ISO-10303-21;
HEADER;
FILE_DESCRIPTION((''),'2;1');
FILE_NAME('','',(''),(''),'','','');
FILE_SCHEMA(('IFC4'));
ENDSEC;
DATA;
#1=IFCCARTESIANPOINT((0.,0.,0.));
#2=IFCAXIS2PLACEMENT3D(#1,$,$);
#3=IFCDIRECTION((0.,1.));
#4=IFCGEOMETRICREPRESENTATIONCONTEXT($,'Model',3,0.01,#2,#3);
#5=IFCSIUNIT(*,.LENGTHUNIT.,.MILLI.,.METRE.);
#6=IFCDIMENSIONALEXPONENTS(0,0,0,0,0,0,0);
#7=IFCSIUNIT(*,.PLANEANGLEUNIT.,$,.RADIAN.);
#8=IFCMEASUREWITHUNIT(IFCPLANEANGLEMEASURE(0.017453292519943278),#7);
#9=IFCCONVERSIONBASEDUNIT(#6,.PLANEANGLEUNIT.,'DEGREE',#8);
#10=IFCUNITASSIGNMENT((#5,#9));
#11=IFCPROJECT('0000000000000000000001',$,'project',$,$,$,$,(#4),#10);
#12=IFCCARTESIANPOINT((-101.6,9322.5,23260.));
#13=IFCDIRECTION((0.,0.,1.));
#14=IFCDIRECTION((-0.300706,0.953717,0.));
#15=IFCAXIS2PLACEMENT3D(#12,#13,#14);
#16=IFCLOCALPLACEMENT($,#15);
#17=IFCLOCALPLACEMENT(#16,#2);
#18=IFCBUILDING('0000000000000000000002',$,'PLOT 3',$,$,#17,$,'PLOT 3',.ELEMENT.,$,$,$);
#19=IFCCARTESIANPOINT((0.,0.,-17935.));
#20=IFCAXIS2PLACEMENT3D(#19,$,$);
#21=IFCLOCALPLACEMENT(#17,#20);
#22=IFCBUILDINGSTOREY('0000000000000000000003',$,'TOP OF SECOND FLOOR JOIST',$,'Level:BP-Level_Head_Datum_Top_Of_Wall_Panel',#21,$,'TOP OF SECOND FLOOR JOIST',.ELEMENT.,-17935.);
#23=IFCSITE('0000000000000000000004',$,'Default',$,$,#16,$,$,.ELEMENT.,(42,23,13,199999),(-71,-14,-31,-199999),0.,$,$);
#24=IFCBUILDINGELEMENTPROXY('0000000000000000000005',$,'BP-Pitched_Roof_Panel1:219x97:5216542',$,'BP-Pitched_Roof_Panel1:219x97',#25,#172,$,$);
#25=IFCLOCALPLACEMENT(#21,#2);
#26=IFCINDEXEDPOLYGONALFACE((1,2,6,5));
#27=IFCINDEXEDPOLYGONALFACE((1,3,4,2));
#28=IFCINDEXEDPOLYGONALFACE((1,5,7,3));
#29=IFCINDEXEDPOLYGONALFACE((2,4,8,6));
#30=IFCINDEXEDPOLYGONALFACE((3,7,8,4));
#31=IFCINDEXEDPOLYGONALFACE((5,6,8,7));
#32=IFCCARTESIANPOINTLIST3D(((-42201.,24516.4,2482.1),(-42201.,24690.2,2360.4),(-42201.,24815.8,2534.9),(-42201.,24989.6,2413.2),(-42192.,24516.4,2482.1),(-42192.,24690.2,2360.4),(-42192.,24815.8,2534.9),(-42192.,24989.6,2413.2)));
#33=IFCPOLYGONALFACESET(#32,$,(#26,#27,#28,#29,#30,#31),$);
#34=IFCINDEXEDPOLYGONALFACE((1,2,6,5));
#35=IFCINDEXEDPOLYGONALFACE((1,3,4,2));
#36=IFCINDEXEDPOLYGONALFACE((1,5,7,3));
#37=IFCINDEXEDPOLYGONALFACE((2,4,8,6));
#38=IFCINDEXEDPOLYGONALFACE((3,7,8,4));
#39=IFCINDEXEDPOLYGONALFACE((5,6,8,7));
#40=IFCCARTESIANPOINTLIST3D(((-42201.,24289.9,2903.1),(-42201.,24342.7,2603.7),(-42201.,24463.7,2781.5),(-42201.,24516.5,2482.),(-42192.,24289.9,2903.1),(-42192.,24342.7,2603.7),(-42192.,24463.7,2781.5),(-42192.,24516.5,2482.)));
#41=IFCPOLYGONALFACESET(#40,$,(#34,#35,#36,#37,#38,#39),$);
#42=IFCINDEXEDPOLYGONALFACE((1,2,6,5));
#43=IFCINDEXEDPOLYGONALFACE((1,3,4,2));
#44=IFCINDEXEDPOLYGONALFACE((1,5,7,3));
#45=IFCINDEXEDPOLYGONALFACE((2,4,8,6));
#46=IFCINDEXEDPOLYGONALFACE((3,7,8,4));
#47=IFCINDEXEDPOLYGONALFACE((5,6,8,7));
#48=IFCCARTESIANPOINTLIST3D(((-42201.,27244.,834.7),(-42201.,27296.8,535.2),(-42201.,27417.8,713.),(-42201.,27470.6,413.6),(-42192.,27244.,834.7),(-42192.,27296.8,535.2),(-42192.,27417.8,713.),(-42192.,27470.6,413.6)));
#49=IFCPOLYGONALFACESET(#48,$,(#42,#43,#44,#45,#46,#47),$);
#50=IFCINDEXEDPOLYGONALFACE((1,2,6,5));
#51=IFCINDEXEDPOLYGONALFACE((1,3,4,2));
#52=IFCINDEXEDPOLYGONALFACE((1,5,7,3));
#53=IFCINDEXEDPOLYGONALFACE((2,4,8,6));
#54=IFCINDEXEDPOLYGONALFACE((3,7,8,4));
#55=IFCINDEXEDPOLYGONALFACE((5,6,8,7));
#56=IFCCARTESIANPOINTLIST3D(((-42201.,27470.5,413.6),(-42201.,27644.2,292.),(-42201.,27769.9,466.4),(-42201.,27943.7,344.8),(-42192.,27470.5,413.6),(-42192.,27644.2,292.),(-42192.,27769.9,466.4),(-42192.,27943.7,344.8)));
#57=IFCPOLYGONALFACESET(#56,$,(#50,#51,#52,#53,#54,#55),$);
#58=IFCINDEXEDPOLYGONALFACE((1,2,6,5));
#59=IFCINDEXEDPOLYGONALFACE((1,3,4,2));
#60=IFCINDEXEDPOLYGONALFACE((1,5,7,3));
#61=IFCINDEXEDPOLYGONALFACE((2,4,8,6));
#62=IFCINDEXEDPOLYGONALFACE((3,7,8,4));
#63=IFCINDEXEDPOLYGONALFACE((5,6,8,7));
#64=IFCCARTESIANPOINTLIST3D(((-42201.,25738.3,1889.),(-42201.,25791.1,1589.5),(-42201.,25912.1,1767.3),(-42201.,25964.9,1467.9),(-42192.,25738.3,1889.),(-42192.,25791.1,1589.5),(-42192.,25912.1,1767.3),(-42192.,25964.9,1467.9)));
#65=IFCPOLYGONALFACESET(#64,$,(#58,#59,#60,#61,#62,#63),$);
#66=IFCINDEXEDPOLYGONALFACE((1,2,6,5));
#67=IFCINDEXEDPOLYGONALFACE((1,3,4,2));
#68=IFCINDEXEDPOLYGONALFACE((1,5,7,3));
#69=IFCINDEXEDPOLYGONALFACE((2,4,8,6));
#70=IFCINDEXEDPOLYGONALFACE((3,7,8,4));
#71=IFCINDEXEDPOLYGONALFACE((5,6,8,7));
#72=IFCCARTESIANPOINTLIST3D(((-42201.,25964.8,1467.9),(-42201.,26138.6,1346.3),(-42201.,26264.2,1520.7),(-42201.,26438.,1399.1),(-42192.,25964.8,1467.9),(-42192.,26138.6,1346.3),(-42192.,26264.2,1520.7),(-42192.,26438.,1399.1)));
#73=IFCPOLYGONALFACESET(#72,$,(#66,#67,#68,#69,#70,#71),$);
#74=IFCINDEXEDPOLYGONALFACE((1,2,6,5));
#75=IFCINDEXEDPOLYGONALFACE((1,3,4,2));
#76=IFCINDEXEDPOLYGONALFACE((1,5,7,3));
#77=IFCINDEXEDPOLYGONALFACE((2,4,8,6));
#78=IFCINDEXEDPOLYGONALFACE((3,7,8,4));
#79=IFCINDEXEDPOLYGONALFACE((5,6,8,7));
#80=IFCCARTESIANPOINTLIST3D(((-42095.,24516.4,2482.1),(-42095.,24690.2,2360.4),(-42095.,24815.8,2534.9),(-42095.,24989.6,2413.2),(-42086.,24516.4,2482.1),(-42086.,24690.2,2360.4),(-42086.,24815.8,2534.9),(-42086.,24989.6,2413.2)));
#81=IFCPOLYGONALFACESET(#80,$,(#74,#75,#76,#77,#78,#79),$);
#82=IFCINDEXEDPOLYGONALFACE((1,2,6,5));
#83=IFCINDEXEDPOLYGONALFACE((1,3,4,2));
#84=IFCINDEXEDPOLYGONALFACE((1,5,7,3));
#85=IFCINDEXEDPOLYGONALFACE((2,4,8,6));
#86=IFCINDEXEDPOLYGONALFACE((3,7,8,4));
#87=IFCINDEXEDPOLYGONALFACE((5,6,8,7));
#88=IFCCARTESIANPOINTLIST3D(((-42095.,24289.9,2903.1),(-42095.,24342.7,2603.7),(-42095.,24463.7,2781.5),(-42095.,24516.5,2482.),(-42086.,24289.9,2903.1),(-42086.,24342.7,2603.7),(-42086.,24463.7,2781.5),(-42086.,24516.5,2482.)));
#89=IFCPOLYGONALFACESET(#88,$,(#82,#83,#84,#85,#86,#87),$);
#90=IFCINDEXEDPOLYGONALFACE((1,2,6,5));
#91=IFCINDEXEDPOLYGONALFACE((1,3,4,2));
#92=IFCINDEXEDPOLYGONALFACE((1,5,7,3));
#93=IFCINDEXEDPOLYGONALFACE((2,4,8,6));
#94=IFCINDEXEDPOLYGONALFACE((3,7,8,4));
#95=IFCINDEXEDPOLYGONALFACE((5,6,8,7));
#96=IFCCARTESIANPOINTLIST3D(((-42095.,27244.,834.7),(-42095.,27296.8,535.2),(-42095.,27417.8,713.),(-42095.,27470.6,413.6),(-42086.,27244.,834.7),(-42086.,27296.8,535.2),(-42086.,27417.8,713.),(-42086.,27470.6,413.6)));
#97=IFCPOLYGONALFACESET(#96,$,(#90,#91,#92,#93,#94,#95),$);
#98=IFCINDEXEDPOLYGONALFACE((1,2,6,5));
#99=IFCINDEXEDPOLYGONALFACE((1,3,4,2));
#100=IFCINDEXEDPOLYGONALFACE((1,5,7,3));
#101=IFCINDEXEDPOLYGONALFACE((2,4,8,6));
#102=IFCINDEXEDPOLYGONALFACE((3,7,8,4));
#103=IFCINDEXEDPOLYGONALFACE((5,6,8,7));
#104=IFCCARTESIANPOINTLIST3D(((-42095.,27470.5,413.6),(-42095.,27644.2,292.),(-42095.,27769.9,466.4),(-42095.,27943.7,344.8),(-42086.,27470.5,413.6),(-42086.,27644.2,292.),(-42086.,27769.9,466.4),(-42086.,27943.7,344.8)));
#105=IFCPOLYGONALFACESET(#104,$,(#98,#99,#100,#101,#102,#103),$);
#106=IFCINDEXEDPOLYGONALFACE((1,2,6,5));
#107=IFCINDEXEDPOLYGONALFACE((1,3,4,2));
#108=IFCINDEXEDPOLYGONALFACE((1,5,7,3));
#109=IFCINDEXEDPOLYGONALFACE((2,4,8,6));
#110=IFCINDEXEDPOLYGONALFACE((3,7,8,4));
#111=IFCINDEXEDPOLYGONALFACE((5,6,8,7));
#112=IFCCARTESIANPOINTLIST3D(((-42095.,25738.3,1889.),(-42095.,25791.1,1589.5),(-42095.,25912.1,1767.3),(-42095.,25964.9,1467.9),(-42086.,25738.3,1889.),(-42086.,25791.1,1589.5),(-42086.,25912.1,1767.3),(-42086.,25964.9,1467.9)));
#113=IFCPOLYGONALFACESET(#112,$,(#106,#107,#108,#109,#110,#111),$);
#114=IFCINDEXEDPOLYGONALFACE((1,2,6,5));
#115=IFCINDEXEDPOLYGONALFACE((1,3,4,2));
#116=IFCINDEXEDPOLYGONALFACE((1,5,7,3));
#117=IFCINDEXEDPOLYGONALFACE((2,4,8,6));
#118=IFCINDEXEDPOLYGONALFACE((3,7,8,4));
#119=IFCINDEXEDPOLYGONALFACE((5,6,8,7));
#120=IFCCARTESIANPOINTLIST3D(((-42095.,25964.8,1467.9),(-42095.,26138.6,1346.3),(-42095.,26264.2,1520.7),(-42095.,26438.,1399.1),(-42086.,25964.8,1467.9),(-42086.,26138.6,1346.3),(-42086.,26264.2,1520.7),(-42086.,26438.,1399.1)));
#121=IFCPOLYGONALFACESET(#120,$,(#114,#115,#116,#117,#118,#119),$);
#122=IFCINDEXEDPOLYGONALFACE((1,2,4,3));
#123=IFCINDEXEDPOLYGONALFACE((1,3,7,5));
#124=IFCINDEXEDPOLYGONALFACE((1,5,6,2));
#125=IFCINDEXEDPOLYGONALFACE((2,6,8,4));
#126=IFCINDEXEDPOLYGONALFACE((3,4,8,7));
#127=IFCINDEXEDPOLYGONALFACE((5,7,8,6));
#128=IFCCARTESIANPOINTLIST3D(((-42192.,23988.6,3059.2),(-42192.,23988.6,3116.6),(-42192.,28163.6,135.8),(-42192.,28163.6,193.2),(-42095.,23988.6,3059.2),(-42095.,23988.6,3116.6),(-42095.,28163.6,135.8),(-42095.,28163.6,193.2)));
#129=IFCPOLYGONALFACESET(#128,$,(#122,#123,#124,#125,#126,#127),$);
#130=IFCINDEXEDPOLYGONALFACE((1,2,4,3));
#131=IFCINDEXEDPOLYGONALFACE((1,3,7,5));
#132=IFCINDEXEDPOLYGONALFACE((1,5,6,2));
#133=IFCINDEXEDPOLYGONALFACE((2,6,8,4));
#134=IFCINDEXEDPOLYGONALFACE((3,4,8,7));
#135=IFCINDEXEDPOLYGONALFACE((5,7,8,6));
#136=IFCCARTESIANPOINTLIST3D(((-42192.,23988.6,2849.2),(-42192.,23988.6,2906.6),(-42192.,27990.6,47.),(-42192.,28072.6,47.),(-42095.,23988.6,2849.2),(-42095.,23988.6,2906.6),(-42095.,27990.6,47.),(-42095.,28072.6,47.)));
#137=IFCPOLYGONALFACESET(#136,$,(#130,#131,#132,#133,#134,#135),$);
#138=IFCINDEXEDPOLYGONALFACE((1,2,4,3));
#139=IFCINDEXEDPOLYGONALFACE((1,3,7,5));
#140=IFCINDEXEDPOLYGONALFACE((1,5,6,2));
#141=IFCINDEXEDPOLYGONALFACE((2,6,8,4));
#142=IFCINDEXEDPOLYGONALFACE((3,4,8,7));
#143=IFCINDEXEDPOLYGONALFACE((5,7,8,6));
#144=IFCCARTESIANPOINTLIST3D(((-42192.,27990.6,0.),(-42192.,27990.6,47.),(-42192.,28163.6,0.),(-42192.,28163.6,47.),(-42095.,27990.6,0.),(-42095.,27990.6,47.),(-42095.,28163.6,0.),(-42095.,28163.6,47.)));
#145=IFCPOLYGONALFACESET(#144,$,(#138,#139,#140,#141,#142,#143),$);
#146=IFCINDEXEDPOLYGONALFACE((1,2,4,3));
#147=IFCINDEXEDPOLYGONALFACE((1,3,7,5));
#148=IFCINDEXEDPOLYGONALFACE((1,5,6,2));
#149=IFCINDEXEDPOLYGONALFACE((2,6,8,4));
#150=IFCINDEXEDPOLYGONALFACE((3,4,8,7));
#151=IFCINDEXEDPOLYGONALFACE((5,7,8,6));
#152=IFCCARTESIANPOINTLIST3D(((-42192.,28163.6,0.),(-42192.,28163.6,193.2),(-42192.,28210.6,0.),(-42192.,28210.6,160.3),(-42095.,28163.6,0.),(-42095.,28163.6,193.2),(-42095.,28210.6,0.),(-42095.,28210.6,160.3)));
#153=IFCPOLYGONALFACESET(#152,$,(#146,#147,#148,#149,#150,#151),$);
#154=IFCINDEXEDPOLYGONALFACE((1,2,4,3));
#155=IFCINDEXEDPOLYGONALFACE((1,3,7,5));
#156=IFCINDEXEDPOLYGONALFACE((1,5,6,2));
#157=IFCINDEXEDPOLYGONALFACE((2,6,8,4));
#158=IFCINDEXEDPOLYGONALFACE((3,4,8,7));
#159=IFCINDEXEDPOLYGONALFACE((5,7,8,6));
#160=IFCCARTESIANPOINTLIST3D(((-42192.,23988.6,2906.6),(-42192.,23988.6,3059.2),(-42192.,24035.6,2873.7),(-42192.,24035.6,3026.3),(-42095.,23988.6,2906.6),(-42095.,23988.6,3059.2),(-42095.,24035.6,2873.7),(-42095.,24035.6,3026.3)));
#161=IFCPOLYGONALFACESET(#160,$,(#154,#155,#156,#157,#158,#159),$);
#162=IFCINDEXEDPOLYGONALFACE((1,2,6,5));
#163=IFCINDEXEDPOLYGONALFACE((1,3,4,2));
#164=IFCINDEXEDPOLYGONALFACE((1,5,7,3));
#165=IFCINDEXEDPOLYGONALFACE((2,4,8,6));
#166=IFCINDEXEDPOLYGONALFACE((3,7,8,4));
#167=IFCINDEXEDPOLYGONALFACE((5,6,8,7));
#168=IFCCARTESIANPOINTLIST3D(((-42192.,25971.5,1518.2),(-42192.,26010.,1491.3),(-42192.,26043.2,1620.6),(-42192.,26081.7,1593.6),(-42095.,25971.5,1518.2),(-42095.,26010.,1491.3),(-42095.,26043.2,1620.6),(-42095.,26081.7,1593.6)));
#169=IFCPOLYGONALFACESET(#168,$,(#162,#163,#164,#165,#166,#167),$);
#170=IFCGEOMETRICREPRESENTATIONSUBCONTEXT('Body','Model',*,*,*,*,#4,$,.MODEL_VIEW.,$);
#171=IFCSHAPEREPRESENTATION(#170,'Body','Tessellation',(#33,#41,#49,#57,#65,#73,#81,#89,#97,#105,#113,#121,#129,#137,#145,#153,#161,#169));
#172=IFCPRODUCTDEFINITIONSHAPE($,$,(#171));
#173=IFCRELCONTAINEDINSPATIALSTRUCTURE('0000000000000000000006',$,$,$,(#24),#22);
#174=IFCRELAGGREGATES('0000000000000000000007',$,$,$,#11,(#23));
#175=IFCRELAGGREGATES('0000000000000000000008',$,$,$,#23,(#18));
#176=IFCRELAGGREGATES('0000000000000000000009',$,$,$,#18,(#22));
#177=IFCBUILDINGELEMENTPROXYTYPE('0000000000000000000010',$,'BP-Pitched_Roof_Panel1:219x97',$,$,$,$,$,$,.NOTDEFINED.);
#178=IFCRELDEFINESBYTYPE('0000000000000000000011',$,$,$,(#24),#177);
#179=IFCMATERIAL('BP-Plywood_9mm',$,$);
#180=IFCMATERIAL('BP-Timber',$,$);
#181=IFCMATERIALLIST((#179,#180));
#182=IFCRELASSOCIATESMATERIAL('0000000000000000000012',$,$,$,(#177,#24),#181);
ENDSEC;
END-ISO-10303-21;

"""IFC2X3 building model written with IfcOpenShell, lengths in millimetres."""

from ifc_helpers import new_model, entity, si_unit, converted_unit, direction, frame, frame_2d, origin, origin_2d_with_axis, place, context, subcontext, project, spatial, polyline, rectangle, outline, extrude, source, transform, mapped, material, material_list, type_object, type_shapes, element, save


model = new_model("IFC2X3")

# Units and contexts
model_context = context("Model", 3, precision=0.01, world=origin(), true_north=direction((0.0, 1.0)))
body_context = subcontext(model_context, "Body", "Model", "MODEL_VIEW")
ifc_project = project(units=[si_unit("LENGTHUNIT", "METRE", prefix="MILLI"), converted_unit("PLANEANGLEUNIT", "DEGREE", entity("IfcPlaneAngleMeasure", 0.017453292519943278), si_unit("PLANEANGLEUNIT", "RADIAN"), dimensions=[0, 0, 0, 0, 0, 0, 0])], contexts=[model_context])

# Site, building, storey
site_placement = place(None, frame((-101.6, 9322.5, 23260.0), z_axis=(0.0, 0.0, 1.0), x_axis=(-0.300706, 0.953717, 0.0)))
site = spatial("IfcSite", under=ifc_project, at=site_placement, Name="Default", CompositionType="ELEMENT", RefLatitude=(42, 23, 13, 199999), RefLongitude=(-71, -14, -31, -199999), RefElevation=0.0)
building_placement = place(site_placement, origin())
building = spatial("IfcBuilding", under=site, at=building_placement, Name="PLOT 3", LongName="PLOT 3", CompositionType="ELEMENT")
storey_placement = place(building_placement, frame((0.0, 0.0, -17935.0)))
storey = spatial("IfcBuildingStorey", under=building, at=storey_placement, Name="TOP OF SECOND FLOOR JOIST", ObjectType="Level:BP-Level_Head_Datum_Top_Of_Wall_Panel", LongName="TOP OF SECOND FLOOR JOIST", CompositionType="ELEMENT", Elevation=-17935.0)

# Building element proxy
ifc_material_1 = material(Name="BP-Timber")
ifc_material_2 = material(Name="BP-Plywood_9mm")
ifc_material_list = material_list([ifc_material_2, ifc_material_1])
building_element_proxy_type_1 = type_object("IfcBuildingElementProxyType", Name="BP-Pitched_Roof_Panel1:219x97", PredefinedType="NOTDEFINED", material=ifc_material_list)
shared_shape_1 = source(origin(), body_context, "Body", "SweptSolid", [
    extrude(outline(polyline([(-77.0, -75.0), (227.0, -75.0), (77.0, 75.0), (-227.0, 75.0), (-77.0, -75.0)])), frame((35.3, -3956.0, 2447.7), z_axis=(0.0, 1.0, 0.0), x_axis=(-0.984808, 0.0, 0.173648)), (0.0, 0.0, 1.0), 9.0),
    extrude(outline(polyline([(1.4, -107.5), (213.6, -107.5), (-1.4, 107.5), (-213.6, 107.5), (1.4, -107.5)])), frame((385.1, -3956.0, 2692.6), z_axis=(0.0, 1.0, 0.0), x_axis=(-0.819152, 0.0, -0.573576)), (0.0, 0.0, 1.0), 9.0),
    extrude(outline(polyline([(1.4, -107.5), (213.6, -107.5), (-1.4, 107.5), (-213.6, 107.5), (1.4, -107.5)])), frame((-2569.0, -3956.0, 624.1), z_axis=(0.0, 1.0, 0.0), x_axis=(-0.819152, 0.0, -0.573576)), (0.0, 0.0, 1.0), 9.0),
    extrude(outline(polyline([(-77.0, -75.0), (227.0, -75.0), (77.0, 75.0), (-227.0, 75.0), (-77.0, -75.0)])), frame((-2918.8, -3956.0, 379.2), z_axis=(0.0, 1.0, 0.0), x_axis=(-0.984808, 0.0, 0.173648)), (0.0, 0.0, 1.0), 9.0),
    extrude(outline(polyline([(1.4, -107.5), (213.6, -107.5), (-1.4, 107.5), (-213.6, 107.5), (1.4, -107.5)])), frame((-1063.3, -3956.0, 1678.4), z_axis=(0.0, 1.0, 0.0), x_axis=(-0.819152, 0.0, -0.573576)), (0.0, 0.0, 1.0), 9.0),
    extrude(outline(polyline([(-77.0, -75.0), (227.0, -75.0), (77.0, 75.0), (-227.0, 75.0), (-77.0, -75.0)])), frame((-1413.1, -3956.0, 1433.5), z_axis=(0.0, 1.0, 0.0), x_axis=(-0.984808, 0.0, 0.173648)), (0.0, 0.0, 1.0), 9.0),
    extrude(outline(polyline([(-77.0, -75.0), (227.0, -75.0), (77.0, 75.0), (-227.0, 75.0), (-77.0, -75.0)])), frame((35.3, -3850.0, 2447.7), z_axis=(0.0, 1.0, 0.0), x_axis=(-0.984808, 0.0, 0.173648)), (0.0, 0.0, 1.0), 9.0),
    extrude(outline(polyline([(1.4, -107.5), (213.6, -107.5), (-1.4, 107.5), (-213.6, 107.5), (1.4, -107.5)])), frame((385.1, -3850.0, 2692.6), z_axis=(0.0, 1.0, 0.0), x_axis=(-0.819152, 0.0, -0.573576)), (0.0, 0.0, 1.0), 9.0),
    extrude(outline(polyline([(1.4, -107.5), (213.6, -107.5), (-1.4, 107.5), (-213.6, 107.5), (1.4, -107.5)])), frame((-2569.0, -3850.0, 624.1), z_axis=(0.0, 1.0, 0.0), x_axis=(-0.819152, 0.0, -0.573576)), (0.0, 0.0, 1.0), 9.0),
    extrude(outline(polyline([(-77.0, -75.0), (227.0, -75.0), (77.0, 75.0), (-227.0, 75.0), (-77.0, -75.0)])), frame((-2918.8, -3850.0, 379.2), z_axis=(0.0, 1.0, 0.0), x_axis=(-0.984808, 0.0, 0.173648)), (0.0, 0.0, 1.0), 9.0),
    extrude(outline(polyline([(1.4, -107.5), (213.6, -107.5), (-1.4, 107.5), (-213.6, 107.5), (1.4, -107.5)])), frame((-1063.3, -3850.0, 1678.4), z_axis=(0.0, 1.0, 0.0), x_axis=(-0.819152, 0.0, -0.573576)), (0.0, 0.0, 1.0), 9.0),
    extrude(outline(polyline([(-77.0, -75.0), (227.0, -75.0), (77.0, 75.0), (-227.0, 75.0), (-77.0, -75.0)])), frame((-1413.1, -3850.0, 1433.5), z_axis=(0.0, 1.0, 0.0), x_axis=(-0.984808, 0.0, 0.173648)), (0.0, 0.0, 1.0), 9.0),
    extrude(outline(polyline([(-1490.4, -2087.5), (-1433.0, -2087.5), (1490.4, 2087.5), (1433.0, 2087.5), (-1490.4, -2087.5)])), frame((-1287.8, -3947.0, 1626.2), z_axis=(0.0, 1.0, 0.0), x_axis=(0.0, 0.0, -1.0)), (0.0, 0.0, 1.0), 97.0),
    extrude(outline(polyline([(-1444.1, -2021.5), (-1386.8, -2021.5), (1415.5, 1980.5), (1415.5, 2062.5), (-1444.1, -2021.5)])), frame((-1221.8, -3947.0, 1462.5), z_axis=(0.0, 1.0, 0.0), x_axis=(0.0, 0.0, -1.0)), (0.0, 0.0, 1.0), 97.0),
    extrude(rectangle(XDim=173.0, YDim=97.0, at=origin_2d_with_axis()), frame((-3288.8, -3898.5, 0.0), z_axis=(0.0, 0.0, 1.0), x_axis=(-1.0, 0.0, 0.0)), (0.0, 0.0, 1.0), 47.0),
    extrude(outline(polyline([(22.0, -72.4), (79.4, -72.4), (-31.4, 85.9), (-69.9, 58.9), (22.0, -72.4)])), frame((-3398.8, -3947.0, 88.4), z_axis=(0.0, 1.0, 0.0), x_axis=(0.819152, 0.0, 0.573576)), (0.0, 0.0, 1.0), 97.0),
    extrude(outline(polyline([(15.1, -62.5), (72.5, -62.5), (-15.1, 62.5), (-72.5, 62.5), (15.1, -62.5)])), frame((776.2, -3947.0, 2966.5), z_axis=(0.0, 1.0, 0.0), x_axis=(0.819152, 0.0, 0.573576)), (0.0, 0.0, 1.0), 97.0),
    extrude(rectangle(XDim=47.0, YDim=97.0, at=frame_2d((0.0, 0.0), x_axis=(1.0, 0.0))), frame((-1202.4, -3898.5, 1504.7), z_axis=(-0.573576, 0.0, 0.819152), x_axis=(-0.819152, 0.0, -0.573576)), (0.0, 0.0, 1.0), 125.0),
])
type_shapes(building_element_proxy_type_1, [shared_shape_1])
for number, where, z_axis, x_axis, name in (
    (1, (-38245.0, 24788.3, 0.0), (0.0, 0.0, 1.0), (0.0, -1.0, 0.0), "BP-Pitched_Roof_Panel1:219x97:5216542"),
):
    element("IfcBuildingElementProxy", number, at=place(storey_placement, frame(where, z_axis=z_axis, x_axis=x_axis)), inside=storey, type_object=building_element_proxy_type_1, material=ifc_material_list, Name=name, ObjectType="BP-Pitched_Roof_Panel1:219x97", context=body_context, shape_type="MappedRepresentation", body=[
        mapped(shared_shape_1, transform((0.0, 0.0, 0.0), scale=1.0)),
    ])

save(model, "model.ifc")
